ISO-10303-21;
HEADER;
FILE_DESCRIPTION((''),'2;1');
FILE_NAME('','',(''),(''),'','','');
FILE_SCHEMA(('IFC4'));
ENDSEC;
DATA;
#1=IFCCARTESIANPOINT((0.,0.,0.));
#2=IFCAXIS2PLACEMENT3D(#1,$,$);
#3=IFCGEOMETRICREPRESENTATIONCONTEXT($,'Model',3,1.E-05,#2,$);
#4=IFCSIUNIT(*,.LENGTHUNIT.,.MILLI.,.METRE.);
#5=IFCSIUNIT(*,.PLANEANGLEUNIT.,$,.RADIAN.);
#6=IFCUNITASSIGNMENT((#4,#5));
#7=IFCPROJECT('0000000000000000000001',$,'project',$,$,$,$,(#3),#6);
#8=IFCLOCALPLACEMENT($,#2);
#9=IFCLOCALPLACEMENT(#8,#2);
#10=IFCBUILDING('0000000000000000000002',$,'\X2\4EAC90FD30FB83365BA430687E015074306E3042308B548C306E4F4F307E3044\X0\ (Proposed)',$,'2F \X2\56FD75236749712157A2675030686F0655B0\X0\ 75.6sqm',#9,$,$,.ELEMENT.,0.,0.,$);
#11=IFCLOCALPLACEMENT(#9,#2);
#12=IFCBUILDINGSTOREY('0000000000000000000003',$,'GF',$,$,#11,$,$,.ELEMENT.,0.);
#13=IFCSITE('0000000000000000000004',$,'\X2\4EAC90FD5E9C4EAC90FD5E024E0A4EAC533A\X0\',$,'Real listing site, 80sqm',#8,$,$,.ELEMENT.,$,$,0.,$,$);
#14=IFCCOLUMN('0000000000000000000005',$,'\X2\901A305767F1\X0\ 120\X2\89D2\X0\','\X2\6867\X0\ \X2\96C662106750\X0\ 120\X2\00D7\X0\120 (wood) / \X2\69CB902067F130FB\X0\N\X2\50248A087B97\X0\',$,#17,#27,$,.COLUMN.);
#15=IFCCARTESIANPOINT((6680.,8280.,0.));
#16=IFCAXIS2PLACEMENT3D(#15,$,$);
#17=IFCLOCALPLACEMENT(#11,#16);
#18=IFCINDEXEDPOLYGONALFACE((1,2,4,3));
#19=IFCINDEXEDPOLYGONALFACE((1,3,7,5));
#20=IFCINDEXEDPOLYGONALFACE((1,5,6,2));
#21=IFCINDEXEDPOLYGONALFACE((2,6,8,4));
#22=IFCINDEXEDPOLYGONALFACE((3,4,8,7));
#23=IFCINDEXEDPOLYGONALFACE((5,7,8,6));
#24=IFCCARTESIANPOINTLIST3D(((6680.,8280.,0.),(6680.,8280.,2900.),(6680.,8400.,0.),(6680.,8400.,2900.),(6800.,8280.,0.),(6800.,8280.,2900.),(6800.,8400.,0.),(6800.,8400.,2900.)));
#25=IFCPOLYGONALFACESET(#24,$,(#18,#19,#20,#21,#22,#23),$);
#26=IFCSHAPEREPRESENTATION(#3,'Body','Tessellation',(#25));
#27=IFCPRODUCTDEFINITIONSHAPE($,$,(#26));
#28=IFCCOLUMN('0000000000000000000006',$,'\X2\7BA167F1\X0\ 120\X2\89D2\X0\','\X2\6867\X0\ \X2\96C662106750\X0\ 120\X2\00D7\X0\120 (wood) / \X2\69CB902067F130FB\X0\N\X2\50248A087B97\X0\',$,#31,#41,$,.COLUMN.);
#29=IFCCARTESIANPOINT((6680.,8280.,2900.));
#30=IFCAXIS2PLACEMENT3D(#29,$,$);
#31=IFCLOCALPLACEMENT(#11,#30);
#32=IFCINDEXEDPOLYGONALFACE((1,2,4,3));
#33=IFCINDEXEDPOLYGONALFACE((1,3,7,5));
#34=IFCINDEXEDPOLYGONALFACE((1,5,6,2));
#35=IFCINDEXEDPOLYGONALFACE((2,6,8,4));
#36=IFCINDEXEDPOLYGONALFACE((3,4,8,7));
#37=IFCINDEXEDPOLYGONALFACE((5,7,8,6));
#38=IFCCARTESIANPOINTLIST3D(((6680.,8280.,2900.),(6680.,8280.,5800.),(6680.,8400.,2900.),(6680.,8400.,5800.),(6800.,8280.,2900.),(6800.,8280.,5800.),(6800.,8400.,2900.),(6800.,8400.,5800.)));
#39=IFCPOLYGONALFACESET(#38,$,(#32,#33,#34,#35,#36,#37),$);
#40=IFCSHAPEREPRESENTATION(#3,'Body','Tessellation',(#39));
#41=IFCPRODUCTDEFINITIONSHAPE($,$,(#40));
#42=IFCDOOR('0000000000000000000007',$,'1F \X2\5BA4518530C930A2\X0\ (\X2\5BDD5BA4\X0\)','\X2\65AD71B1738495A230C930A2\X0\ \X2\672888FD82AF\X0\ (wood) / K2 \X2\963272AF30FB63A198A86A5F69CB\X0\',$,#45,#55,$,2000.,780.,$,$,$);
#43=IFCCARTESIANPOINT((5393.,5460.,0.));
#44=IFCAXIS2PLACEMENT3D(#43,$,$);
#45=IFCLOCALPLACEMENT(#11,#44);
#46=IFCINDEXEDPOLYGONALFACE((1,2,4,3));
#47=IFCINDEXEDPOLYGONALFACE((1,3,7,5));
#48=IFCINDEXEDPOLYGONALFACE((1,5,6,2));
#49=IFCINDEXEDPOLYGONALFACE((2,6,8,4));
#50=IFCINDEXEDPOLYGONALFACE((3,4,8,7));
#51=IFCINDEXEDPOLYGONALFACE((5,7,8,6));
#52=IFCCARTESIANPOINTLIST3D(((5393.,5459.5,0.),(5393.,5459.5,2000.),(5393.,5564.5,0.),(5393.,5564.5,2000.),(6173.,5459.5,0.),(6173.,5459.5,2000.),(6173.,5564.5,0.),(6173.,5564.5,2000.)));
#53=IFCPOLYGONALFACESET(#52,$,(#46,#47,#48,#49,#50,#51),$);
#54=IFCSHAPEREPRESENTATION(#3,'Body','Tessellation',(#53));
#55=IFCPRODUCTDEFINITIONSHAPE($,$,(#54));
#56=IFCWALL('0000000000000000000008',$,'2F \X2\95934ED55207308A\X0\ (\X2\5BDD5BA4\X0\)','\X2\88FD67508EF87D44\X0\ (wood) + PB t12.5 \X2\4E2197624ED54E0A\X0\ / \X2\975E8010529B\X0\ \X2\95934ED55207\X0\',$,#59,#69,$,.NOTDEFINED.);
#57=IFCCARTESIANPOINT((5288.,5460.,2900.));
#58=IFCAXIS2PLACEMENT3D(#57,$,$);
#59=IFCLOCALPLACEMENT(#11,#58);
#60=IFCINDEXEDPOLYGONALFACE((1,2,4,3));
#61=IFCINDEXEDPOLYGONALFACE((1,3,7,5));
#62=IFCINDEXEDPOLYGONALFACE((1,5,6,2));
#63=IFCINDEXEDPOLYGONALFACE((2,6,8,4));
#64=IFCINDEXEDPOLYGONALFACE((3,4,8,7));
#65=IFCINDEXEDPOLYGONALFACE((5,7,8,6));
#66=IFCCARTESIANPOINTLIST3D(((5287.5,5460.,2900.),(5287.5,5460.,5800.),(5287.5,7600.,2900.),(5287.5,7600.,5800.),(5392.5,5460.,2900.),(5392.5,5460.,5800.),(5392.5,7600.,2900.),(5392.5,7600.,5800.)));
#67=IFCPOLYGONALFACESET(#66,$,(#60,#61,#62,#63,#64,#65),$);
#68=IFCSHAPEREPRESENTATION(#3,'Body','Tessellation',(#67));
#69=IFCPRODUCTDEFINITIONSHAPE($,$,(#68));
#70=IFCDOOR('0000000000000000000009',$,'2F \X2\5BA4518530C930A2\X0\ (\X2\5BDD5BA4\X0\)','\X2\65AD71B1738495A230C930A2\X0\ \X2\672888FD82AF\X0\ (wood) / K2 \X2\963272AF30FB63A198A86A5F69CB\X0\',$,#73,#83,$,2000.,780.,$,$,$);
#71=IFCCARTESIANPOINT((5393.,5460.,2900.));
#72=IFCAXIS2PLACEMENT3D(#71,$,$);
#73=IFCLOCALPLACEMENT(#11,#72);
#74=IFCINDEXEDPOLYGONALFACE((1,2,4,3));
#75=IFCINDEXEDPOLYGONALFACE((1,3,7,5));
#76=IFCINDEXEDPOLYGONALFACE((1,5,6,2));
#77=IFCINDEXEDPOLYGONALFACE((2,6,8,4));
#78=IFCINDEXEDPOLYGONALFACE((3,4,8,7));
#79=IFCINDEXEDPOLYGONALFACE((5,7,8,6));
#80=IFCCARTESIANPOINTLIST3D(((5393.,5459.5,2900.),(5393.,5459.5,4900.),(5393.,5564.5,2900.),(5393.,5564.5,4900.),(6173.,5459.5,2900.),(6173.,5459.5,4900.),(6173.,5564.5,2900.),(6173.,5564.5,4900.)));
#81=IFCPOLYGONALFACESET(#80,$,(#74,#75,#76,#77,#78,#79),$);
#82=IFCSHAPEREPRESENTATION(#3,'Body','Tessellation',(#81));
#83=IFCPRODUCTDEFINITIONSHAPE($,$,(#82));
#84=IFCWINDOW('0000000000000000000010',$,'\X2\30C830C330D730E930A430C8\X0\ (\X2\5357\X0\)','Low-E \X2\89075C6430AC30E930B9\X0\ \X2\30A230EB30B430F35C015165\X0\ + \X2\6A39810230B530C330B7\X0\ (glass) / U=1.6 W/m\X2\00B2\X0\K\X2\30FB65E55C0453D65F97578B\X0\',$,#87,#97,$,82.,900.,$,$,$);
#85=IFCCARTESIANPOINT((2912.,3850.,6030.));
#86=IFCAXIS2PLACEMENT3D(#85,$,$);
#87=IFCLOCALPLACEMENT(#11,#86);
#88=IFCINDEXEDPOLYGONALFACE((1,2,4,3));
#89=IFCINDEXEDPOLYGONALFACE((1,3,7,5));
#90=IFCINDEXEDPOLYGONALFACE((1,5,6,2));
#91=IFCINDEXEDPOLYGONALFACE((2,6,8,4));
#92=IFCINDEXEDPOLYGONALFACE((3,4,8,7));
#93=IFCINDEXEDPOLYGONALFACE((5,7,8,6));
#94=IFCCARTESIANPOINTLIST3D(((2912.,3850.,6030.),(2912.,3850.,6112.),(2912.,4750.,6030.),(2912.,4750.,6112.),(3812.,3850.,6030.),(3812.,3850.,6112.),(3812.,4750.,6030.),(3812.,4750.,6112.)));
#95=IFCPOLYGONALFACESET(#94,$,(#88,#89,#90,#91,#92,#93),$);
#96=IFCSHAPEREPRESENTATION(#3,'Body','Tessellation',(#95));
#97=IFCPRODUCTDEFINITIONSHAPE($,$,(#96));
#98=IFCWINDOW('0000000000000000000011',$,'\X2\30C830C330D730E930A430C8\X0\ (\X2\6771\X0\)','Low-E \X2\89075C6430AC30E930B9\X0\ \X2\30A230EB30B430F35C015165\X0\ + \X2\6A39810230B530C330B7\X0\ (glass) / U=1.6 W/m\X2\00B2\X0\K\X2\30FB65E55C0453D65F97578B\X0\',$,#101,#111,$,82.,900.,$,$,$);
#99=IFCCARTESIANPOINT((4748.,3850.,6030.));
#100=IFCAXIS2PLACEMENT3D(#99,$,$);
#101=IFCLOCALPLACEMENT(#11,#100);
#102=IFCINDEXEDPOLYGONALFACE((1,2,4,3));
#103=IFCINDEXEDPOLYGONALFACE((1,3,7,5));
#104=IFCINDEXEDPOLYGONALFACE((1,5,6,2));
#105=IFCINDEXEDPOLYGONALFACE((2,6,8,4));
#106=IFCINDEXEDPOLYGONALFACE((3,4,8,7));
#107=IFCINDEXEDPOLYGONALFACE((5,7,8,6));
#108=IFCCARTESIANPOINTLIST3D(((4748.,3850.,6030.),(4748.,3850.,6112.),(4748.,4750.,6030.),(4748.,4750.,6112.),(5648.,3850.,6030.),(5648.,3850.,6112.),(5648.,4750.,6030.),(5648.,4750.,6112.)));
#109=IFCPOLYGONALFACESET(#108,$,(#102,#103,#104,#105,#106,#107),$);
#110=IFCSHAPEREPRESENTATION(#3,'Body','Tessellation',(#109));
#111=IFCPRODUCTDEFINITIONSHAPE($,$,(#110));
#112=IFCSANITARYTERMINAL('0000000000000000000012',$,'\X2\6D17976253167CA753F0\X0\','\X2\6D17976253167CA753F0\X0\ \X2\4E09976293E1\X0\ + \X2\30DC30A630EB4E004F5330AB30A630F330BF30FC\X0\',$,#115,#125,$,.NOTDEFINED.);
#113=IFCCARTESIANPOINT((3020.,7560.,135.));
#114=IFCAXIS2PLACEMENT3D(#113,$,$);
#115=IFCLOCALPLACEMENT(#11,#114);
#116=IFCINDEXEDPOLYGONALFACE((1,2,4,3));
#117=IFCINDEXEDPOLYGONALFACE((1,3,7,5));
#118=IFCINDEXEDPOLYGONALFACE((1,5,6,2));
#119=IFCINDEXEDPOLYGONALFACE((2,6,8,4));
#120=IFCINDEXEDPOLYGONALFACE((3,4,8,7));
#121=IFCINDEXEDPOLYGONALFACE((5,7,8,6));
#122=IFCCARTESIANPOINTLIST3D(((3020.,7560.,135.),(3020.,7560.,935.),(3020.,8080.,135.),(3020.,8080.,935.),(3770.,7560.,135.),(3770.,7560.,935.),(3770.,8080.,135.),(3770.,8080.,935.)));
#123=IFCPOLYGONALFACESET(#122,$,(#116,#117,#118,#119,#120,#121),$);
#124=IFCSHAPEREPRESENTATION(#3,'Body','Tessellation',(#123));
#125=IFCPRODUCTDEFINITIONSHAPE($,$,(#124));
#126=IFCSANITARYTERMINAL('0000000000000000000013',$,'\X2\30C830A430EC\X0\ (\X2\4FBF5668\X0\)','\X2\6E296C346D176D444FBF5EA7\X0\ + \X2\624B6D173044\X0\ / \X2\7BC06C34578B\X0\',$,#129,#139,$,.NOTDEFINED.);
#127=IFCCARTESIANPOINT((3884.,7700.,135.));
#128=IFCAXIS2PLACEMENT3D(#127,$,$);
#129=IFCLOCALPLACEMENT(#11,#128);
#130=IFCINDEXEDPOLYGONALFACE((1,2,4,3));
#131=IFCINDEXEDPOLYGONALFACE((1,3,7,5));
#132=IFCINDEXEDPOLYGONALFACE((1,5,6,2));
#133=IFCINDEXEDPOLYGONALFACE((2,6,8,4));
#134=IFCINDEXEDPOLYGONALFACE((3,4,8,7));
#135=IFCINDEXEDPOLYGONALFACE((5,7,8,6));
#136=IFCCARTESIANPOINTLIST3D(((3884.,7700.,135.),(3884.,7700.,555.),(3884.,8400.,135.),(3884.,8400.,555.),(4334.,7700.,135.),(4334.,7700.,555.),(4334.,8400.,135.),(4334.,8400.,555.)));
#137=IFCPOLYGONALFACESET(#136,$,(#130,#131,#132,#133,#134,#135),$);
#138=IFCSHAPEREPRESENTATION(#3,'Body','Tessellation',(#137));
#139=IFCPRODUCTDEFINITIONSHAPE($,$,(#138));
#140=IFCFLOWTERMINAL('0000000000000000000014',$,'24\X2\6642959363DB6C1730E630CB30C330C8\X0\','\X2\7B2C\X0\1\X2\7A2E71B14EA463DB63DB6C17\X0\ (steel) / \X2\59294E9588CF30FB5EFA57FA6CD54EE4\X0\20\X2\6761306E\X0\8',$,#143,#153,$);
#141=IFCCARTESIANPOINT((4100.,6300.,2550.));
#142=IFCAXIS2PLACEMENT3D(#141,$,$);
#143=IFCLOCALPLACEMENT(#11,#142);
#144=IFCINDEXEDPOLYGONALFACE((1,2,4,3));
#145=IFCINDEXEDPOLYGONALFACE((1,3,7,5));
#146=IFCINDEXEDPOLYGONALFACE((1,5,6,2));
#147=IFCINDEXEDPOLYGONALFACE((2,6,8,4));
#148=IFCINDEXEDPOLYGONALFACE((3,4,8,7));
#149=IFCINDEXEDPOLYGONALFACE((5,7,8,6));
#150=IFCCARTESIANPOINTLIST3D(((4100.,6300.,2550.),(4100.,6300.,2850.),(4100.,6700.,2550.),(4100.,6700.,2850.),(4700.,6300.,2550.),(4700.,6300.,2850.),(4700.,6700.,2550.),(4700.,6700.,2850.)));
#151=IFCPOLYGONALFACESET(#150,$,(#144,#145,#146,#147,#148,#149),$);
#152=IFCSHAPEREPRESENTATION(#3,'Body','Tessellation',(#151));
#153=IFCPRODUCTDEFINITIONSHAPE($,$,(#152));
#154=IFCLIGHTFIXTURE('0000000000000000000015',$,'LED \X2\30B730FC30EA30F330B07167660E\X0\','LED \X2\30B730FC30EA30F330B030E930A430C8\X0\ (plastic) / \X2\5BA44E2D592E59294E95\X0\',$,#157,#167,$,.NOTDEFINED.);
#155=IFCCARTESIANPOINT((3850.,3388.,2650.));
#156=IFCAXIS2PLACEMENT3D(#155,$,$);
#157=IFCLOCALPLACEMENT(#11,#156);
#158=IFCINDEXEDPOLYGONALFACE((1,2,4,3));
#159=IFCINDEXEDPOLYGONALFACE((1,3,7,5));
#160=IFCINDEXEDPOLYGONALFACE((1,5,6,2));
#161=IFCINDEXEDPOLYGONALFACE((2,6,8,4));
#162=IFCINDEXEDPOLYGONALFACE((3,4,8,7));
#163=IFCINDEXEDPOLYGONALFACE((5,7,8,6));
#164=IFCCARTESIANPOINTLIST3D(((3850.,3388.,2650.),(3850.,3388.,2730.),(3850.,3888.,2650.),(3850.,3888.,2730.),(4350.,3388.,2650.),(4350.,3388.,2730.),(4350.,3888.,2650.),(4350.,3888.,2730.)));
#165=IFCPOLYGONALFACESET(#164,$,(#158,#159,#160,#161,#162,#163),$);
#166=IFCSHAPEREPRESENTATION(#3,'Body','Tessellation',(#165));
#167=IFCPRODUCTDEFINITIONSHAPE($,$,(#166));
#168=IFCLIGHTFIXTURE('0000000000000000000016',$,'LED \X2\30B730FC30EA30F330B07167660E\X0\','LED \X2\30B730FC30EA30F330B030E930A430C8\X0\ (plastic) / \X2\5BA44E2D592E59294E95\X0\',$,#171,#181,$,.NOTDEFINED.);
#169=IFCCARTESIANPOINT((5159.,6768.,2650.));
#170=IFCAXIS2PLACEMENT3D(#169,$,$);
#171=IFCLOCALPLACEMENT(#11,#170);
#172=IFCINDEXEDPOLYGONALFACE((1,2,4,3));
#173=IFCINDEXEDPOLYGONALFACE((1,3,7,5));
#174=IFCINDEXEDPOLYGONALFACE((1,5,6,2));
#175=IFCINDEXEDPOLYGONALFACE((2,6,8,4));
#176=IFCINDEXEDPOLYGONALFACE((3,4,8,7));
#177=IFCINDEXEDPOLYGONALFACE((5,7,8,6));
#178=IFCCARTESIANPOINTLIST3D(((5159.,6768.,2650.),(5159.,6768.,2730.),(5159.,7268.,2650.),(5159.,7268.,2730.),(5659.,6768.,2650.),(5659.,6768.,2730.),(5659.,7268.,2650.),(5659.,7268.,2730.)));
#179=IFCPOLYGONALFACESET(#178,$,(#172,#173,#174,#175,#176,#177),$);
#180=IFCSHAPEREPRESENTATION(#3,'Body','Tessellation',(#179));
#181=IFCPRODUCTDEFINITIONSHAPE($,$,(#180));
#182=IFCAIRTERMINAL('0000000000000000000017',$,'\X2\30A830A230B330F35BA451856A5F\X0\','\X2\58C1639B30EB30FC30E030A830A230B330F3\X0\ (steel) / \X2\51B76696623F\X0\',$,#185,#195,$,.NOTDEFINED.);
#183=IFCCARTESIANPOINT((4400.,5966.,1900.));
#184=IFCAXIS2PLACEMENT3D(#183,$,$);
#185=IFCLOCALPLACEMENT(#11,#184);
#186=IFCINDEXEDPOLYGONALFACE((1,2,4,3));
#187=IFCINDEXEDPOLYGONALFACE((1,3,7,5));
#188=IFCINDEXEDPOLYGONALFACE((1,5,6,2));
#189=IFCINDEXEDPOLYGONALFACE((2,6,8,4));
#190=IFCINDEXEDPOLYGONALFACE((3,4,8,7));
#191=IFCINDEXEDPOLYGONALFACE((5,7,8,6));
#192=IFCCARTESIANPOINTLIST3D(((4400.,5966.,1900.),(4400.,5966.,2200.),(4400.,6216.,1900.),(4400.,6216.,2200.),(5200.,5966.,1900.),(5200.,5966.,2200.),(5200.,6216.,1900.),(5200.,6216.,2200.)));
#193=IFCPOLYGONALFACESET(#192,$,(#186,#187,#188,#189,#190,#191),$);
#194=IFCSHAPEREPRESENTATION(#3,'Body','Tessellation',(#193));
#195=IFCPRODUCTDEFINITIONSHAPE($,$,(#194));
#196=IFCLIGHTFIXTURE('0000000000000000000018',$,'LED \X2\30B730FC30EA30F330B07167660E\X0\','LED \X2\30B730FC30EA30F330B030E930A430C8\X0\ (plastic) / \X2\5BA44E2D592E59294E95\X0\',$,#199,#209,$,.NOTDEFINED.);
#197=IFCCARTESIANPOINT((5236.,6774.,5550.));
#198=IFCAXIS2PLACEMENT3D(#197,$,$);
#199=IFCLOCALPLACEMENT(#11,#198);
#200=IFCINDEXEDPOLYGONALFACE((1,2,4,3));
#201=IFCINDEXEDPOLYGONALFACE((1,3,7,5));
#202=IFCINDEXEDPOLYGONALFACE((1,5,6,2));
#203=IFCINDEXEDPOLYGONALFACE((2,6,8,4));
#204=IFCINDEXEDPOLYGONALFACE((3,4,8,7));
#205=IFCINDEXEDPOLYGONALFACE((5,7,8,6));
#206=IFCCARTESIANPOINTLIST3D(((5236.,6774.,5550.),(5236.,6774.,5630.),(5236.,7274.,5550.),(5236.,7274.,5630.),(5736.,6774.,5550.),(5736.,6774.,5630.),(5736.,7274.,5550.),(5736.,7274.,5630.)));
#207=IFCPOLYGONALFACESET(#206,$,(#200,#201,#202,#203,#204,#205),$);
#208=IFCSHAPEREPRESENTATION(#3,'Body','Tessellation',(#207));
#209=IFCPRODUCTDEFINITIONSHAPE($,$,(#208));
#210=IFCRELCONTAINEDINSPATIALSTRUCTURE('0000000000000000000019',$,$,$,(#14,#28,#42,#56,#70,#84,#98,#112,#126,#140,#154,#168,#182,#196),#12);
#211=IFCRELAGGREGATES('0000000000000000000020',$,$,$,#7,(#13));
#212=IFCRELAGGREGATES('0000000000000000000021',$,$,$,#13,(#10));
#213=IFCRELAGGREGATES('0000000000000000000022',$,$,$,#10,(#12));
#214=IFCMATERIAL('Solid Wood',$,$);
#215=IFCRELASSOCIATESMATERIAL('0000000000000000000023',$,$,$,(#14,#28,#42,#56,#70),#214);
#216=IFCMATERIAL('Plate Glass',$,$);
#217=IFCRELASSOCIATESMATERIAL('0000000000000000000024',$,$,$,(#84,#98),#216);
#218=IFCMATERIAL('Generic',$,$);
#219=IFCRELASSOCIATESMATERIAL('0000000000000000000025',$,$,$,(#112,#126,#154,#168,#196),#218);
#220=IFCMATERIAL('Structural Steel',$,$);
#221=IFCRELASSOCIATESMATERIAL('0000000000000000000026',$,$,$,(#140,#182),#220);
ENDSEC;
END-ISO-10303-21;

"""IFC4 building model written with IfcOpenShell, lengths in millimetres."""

from ifc_helpers import new_model, si_unit, frame, frame_2d, origin, place, context, project, spatial, rectangle, extrude, material, element, save


model = new_model("IFC4")

# Units and contexts
model_context = context("Model", 3, precision=1e-05, world=origin())
ifc_project = project(units=[si_unit("LENGTHUNIT", "METRE", prefix="MILLI"), si_unit("PLANEANGLEUNIT", "RADIAN")], contexts=[model_context])

# Site, building, storey
site_placement = place(None, origin())
site = spatial("IfcSite", under=ifc_project, at=site_placement, Name="京都府京都市上京区", ObjectType="Real listing site, 80sqm", CompositionType="ELEMENT", RefElevation=0.0)
building_placement = place(site_placement, origin())
building = spatial("IfcBuilding", under=site, at=building_placement, Name="京都・茶室と縁側のある和の住まい (Proposed)", ObjectType="2F 国産杉無垢材と漆喰 75.6sqm", CompositionType="ELEMENT", ElevationOfRefHeight=0.0, ElevationOfTerrain=0.0)
storey_placement = place(building_placement, origin())
storey = spatial("IfcBuildingStorey", under=building, at=storey_placement, Name="GF", CompositionType="ELEMENT", Elevation=0.0)

# Columns
ifc_material_1 = material(Name="Solid Wood")
column_1_placement = place(storey_placement, frame((6680.0, 8280.0, 0.0)))
element("IfcColumn", 1, at=column_1_placement, inside=storey, material=ifc_material_1, Name="通し柱 120角", Description="桧 集成材 120×120 (wood) / 構造柱・N値計算", PredefinedType="COLUMN", context=model_context, shape_type="SweptSolid", body=[
    extrude(rectangle(XDim=120.0, YDim=120.0, at=frame_2d((60.0, 60.0))), frame((6680.0, 8280.0, 0.0)), (0.0, 0.0, 1.0), 2900.0),
])
column_2_placement = place(storey_placement, frame((6680.0, 8280.0, 2900.0)))
element("IfcColumn", 2, at=column_2_placement, inside=storey, material=ifc_material_1, Name="管柱 120角", Description="桧 集成材 120×120 (wood) / 構造柱・N値計算", PredefinedType="COLUMN", context=model_context, shape_type="SweptSolid", body=[
    extrude(rectangle(XDim=120.0, YDim=120.0, at=frame_2d((60.0, 60.0))), frame((6680.0, 8280.0, 2900.0)), (0.0, 0.0, 1.0), 2900.0),
])

# Door
door_1_placement = place(storey_placement, frame((5393.0, 5460.0, 0.0)))
element("IfcDoor", 3, at=door_1_placement, inside=storey, material=ifc_material_1, Name="1F 室内ドア (寝室)", Description="断熱玄関ドア 木製芯 (wood) / K2 防犯・採風機構", OverallHeight=2000.0, OverallWidth=780.0, context=model_context, shape_type="SweptSolid", body=[
    extrude(rectangle(XDim=780.0, YDim=105.0, at=frame_2d((390.0, 52.0))), frame((5393.0, 5460.0, 0.0)), (0.0, 0.0, 1.0), 2000.0),
])

# Wall
wall_1_placement = place(storey_placement, frame((5288.0, 5460.0, 2900.0)))
element("IfcWall", 4, at=wall_1_placement, inside=storey, material=ifc_material_1, Name="2F 間仕切り (寝室)", Description="製材軸組 (wood) + PB t12.5 両面仕上 / 非耐力 間仕切", PredefinedType="NOTDEFINED", context=model_context, shape_type="SweptSolid", body=[
    extrude(rectangle(XDim=105.0, YDim=2140.0, at=frame_2d((52.0, 1070.0))), frame((5288.0, 5460.0, 2900.0)), (0.0, 0.0, 1.0), 2900.0),
])

# Door
door_2_placement = place(storey_placement, frame((5393.0, 5460.0, 2900.0)))
element("IfcDoor", 5, at=door_2_placement, inside=storey, material=ifc_material_1, Name="2F 室内ドア (寝室)", Description="断熱玄関ドア 木製芯 (wood) / K2 防犯・採風機構", OverallHeight=2000.0, OverallWidth=780.0, context=model_context, shape_type="SweptSolid", body=[
    extrude(rectangle(XDim=780.0, YDim=105.0, at=frame_2d((390.0, 52.0))), frame((5393.0, 5460.0, 2900.0)), (0.0, 0.0, 1.0), 2000.0),
])

# Windows
ifc_material_2 = material(Name="Plate Glass")
window_1_placement = place(storey_placement, frame((2912.0, 3850.0, 6030.0)))
element("IfcWindow", 6, at=window_1_placement, inside=storey, material=ifc_material_2, Name="トップライト (南)", Description="Low-E 複層ガラス アルゴン封入 + 樹脂サッシ (glass) / U=1.6 W/m²K・日射取得型", OverallHeight=82.0, OverallWidth=900.0, context=model_context, shape_type="SweptSolid", body=[
    extrude(rectangle(XDim=900.0, YDim=900.0, at=frame_2d((450.0, 450.0))), frame((2912.0, 3850.0, 6030.0)), (0.0, 0.0, 1.0), 82.0),
])
window_2_placement = place(storey_placement, frame((4748.0, 3850.0, 6030.0)))
element("IfcWindow", 7, at=window_2_placement, inside=storey, material=ifc_material_2, Name="トップライト (東)", Description="Low-E 複層ガラス アルゴン封入 + 樹脂サッシ (glass) / U=1.6 W/m²K・日射取得型", OverallHeight=82.0, OverallWidth=900.0, context=model_context, shape_type="SweptSolid", body=[
    extrude(rectangle(XDim=900.0, YDim=900.0, at=frame_2d((450.0, 450.0))), frame((4748.0, 3850.0, 6030.0)), (0.0, 0.0, 1.0), 82.0),
])

# Sanitary terminals
ifc_material_3 = material(Name="Generic")
sanitary_terminal_1_placement = place(storey_placement, frame((3020.0, 7560.0, 135.0)))
element("IfcSanitaryTerminal", 8, at=sanitary_terminal_1_placement, inside=storey, material=ifc_material_3, Name="洗面化粧台", Description="洗面化粧台 三面鏡 + ボウル一体カウンター", PredefinedType="NOTDEFINED", context=model_context, shape_type="SweptSolid", body=[
    extrude(rectangle(XDim=750.0, YDim=520.0, at=frame_2d((375.0, 260.0))), frame((3020.0, 7560.0, 135.0)), (0.0, 0.0, 1.0), 800.0),
])
sanitary_terminal_2_placement = place(storey_placement, frame((3884.0, 7700.0, 135.0)))
element("IfcSanitaryTerminal", 9, at=sanitary_terminal_2_placement, inside=storey, material=ifc_material_3, Name="トイレ (便器)", Description="温水洗浄便座 + 手洗い / 節水型", PredefinedType="NOTDEFINED", context=model_context, shape_type="SweptSolid", body=[
    extrude(rectangle(XDim=450.0, YDim=700.0, at=frame_2d((225.0, 350.0))), frame((3884.0, 7700.0, 135.0)), (0.0, 0.0, 1.0), 420.0),
])

# Flow terminal
ifc_material_4 = material(Name="Structural Steel")
flow_terminal_placement = place(storey_placement, frame((4100.0, 6300.0, 2550.0)))
element("IfcFlowTerminal", 10, at=flow_terminal_placement, inside=storey, material=ifc_material_4, Name="24時間換気ユニット", Description="第1種熱交換換気 (steel) / 天井裏・建基法令20条の8", context=model_context, shape_type="SweptSolid", body=[
    extrude(rectangle(XDim=600.0, YDim=400.0, at=frame_2d((300.0, 200.0))), frame((4100.0, 6300.0, 2550.0)), (0.0, 0.0, 1.0), 300.0),
])

# Light fixtures
light_fixture_1_placement = place(storey_placement, frame((3850.0, 3388.0, 2650.0)))
element("IfcLightFixture", 11, at=light_fixture_1_placement, inside=storey, material=ifc_material_3, Name="LED シーリング照明", Description="LED シーリングライト (plastic) / 室中央天井", PredefinedType="NOTDEFINED", context=model_context, shape_type="SweptSolid", body=[
    extrude(rectangle(XDim=500.0, YDim=500.0, at=frame_2d((250.0, 250.0))), frame((3850.0, 3388.0, 2650.0)), (0.0, 0.0, 1.0), 80.0),
])
light_fixture_2_placement = place(storey_placement, frame((5159.0, 6768.0, 2650.0)))
element("IfcLightFixture", 12, at=light_fixture_2_placement, inside=storey, material=ifc_material_3, Name="LED シーリング照明", Description="LED シーリングライト (plastic) / 室中央天井", PredefinedType="NOTDEFINED", context=model_context, shape_type="SweptSolid", body=[
    extrude(rectangle(XDim=500.0, YDim=500.0, at=frame_2d((250.0, 250.0))), frame((5159.0, 6768.0, 2650.0)), (0.0, 0.0, 1.0), 80.0),
])

# Air terminal
air_terminal_placement = place(storey_placement, frame((4400.0, 5966.0, 1900.0)))
element("IfcAirTerminal", 13, at=air_terminal_placement, inside=storey, material=ifc_material_4, Name="エアコン室内機", Description="壁掛ルームエアコン (steel) / 冷暖房", PredefinedType="NOTDEFINED", context=model_context, shape_type="SweptSolid", body=[
    extrude(rectangle(XDim=800.0, YDim=250.0, at=frame_2d((400.0, 125.0))), frame((4400.0, 5966.0, 1900.0)), (0.0, 0.0, 1.0), 300.0),
])

# Light fixture
light_fixture_3_placement = place(storey_placement, frame((5236.0, 6774.0, 5550.0)))
element("IfcLightFixture", 14, at=light_fixture_3_placement, inside=storey, material=ifc_material_3, Name="LED シーリング照明", Description="LED シーリングライト (plastic) / 室中央天井", PredefinedType="NOTDEFINED", context=model_context, shape_type="SweptSolid", body=[
    extrude(rectangle(XDim=500.0, YDim=500.0, at=frame_2d((250.0, 250.0))), frame((5236.0, 6774.0, 5550.0)), (0.0, 0.0, 1.0), 80.0),
])

save(model, "model.ifc")
